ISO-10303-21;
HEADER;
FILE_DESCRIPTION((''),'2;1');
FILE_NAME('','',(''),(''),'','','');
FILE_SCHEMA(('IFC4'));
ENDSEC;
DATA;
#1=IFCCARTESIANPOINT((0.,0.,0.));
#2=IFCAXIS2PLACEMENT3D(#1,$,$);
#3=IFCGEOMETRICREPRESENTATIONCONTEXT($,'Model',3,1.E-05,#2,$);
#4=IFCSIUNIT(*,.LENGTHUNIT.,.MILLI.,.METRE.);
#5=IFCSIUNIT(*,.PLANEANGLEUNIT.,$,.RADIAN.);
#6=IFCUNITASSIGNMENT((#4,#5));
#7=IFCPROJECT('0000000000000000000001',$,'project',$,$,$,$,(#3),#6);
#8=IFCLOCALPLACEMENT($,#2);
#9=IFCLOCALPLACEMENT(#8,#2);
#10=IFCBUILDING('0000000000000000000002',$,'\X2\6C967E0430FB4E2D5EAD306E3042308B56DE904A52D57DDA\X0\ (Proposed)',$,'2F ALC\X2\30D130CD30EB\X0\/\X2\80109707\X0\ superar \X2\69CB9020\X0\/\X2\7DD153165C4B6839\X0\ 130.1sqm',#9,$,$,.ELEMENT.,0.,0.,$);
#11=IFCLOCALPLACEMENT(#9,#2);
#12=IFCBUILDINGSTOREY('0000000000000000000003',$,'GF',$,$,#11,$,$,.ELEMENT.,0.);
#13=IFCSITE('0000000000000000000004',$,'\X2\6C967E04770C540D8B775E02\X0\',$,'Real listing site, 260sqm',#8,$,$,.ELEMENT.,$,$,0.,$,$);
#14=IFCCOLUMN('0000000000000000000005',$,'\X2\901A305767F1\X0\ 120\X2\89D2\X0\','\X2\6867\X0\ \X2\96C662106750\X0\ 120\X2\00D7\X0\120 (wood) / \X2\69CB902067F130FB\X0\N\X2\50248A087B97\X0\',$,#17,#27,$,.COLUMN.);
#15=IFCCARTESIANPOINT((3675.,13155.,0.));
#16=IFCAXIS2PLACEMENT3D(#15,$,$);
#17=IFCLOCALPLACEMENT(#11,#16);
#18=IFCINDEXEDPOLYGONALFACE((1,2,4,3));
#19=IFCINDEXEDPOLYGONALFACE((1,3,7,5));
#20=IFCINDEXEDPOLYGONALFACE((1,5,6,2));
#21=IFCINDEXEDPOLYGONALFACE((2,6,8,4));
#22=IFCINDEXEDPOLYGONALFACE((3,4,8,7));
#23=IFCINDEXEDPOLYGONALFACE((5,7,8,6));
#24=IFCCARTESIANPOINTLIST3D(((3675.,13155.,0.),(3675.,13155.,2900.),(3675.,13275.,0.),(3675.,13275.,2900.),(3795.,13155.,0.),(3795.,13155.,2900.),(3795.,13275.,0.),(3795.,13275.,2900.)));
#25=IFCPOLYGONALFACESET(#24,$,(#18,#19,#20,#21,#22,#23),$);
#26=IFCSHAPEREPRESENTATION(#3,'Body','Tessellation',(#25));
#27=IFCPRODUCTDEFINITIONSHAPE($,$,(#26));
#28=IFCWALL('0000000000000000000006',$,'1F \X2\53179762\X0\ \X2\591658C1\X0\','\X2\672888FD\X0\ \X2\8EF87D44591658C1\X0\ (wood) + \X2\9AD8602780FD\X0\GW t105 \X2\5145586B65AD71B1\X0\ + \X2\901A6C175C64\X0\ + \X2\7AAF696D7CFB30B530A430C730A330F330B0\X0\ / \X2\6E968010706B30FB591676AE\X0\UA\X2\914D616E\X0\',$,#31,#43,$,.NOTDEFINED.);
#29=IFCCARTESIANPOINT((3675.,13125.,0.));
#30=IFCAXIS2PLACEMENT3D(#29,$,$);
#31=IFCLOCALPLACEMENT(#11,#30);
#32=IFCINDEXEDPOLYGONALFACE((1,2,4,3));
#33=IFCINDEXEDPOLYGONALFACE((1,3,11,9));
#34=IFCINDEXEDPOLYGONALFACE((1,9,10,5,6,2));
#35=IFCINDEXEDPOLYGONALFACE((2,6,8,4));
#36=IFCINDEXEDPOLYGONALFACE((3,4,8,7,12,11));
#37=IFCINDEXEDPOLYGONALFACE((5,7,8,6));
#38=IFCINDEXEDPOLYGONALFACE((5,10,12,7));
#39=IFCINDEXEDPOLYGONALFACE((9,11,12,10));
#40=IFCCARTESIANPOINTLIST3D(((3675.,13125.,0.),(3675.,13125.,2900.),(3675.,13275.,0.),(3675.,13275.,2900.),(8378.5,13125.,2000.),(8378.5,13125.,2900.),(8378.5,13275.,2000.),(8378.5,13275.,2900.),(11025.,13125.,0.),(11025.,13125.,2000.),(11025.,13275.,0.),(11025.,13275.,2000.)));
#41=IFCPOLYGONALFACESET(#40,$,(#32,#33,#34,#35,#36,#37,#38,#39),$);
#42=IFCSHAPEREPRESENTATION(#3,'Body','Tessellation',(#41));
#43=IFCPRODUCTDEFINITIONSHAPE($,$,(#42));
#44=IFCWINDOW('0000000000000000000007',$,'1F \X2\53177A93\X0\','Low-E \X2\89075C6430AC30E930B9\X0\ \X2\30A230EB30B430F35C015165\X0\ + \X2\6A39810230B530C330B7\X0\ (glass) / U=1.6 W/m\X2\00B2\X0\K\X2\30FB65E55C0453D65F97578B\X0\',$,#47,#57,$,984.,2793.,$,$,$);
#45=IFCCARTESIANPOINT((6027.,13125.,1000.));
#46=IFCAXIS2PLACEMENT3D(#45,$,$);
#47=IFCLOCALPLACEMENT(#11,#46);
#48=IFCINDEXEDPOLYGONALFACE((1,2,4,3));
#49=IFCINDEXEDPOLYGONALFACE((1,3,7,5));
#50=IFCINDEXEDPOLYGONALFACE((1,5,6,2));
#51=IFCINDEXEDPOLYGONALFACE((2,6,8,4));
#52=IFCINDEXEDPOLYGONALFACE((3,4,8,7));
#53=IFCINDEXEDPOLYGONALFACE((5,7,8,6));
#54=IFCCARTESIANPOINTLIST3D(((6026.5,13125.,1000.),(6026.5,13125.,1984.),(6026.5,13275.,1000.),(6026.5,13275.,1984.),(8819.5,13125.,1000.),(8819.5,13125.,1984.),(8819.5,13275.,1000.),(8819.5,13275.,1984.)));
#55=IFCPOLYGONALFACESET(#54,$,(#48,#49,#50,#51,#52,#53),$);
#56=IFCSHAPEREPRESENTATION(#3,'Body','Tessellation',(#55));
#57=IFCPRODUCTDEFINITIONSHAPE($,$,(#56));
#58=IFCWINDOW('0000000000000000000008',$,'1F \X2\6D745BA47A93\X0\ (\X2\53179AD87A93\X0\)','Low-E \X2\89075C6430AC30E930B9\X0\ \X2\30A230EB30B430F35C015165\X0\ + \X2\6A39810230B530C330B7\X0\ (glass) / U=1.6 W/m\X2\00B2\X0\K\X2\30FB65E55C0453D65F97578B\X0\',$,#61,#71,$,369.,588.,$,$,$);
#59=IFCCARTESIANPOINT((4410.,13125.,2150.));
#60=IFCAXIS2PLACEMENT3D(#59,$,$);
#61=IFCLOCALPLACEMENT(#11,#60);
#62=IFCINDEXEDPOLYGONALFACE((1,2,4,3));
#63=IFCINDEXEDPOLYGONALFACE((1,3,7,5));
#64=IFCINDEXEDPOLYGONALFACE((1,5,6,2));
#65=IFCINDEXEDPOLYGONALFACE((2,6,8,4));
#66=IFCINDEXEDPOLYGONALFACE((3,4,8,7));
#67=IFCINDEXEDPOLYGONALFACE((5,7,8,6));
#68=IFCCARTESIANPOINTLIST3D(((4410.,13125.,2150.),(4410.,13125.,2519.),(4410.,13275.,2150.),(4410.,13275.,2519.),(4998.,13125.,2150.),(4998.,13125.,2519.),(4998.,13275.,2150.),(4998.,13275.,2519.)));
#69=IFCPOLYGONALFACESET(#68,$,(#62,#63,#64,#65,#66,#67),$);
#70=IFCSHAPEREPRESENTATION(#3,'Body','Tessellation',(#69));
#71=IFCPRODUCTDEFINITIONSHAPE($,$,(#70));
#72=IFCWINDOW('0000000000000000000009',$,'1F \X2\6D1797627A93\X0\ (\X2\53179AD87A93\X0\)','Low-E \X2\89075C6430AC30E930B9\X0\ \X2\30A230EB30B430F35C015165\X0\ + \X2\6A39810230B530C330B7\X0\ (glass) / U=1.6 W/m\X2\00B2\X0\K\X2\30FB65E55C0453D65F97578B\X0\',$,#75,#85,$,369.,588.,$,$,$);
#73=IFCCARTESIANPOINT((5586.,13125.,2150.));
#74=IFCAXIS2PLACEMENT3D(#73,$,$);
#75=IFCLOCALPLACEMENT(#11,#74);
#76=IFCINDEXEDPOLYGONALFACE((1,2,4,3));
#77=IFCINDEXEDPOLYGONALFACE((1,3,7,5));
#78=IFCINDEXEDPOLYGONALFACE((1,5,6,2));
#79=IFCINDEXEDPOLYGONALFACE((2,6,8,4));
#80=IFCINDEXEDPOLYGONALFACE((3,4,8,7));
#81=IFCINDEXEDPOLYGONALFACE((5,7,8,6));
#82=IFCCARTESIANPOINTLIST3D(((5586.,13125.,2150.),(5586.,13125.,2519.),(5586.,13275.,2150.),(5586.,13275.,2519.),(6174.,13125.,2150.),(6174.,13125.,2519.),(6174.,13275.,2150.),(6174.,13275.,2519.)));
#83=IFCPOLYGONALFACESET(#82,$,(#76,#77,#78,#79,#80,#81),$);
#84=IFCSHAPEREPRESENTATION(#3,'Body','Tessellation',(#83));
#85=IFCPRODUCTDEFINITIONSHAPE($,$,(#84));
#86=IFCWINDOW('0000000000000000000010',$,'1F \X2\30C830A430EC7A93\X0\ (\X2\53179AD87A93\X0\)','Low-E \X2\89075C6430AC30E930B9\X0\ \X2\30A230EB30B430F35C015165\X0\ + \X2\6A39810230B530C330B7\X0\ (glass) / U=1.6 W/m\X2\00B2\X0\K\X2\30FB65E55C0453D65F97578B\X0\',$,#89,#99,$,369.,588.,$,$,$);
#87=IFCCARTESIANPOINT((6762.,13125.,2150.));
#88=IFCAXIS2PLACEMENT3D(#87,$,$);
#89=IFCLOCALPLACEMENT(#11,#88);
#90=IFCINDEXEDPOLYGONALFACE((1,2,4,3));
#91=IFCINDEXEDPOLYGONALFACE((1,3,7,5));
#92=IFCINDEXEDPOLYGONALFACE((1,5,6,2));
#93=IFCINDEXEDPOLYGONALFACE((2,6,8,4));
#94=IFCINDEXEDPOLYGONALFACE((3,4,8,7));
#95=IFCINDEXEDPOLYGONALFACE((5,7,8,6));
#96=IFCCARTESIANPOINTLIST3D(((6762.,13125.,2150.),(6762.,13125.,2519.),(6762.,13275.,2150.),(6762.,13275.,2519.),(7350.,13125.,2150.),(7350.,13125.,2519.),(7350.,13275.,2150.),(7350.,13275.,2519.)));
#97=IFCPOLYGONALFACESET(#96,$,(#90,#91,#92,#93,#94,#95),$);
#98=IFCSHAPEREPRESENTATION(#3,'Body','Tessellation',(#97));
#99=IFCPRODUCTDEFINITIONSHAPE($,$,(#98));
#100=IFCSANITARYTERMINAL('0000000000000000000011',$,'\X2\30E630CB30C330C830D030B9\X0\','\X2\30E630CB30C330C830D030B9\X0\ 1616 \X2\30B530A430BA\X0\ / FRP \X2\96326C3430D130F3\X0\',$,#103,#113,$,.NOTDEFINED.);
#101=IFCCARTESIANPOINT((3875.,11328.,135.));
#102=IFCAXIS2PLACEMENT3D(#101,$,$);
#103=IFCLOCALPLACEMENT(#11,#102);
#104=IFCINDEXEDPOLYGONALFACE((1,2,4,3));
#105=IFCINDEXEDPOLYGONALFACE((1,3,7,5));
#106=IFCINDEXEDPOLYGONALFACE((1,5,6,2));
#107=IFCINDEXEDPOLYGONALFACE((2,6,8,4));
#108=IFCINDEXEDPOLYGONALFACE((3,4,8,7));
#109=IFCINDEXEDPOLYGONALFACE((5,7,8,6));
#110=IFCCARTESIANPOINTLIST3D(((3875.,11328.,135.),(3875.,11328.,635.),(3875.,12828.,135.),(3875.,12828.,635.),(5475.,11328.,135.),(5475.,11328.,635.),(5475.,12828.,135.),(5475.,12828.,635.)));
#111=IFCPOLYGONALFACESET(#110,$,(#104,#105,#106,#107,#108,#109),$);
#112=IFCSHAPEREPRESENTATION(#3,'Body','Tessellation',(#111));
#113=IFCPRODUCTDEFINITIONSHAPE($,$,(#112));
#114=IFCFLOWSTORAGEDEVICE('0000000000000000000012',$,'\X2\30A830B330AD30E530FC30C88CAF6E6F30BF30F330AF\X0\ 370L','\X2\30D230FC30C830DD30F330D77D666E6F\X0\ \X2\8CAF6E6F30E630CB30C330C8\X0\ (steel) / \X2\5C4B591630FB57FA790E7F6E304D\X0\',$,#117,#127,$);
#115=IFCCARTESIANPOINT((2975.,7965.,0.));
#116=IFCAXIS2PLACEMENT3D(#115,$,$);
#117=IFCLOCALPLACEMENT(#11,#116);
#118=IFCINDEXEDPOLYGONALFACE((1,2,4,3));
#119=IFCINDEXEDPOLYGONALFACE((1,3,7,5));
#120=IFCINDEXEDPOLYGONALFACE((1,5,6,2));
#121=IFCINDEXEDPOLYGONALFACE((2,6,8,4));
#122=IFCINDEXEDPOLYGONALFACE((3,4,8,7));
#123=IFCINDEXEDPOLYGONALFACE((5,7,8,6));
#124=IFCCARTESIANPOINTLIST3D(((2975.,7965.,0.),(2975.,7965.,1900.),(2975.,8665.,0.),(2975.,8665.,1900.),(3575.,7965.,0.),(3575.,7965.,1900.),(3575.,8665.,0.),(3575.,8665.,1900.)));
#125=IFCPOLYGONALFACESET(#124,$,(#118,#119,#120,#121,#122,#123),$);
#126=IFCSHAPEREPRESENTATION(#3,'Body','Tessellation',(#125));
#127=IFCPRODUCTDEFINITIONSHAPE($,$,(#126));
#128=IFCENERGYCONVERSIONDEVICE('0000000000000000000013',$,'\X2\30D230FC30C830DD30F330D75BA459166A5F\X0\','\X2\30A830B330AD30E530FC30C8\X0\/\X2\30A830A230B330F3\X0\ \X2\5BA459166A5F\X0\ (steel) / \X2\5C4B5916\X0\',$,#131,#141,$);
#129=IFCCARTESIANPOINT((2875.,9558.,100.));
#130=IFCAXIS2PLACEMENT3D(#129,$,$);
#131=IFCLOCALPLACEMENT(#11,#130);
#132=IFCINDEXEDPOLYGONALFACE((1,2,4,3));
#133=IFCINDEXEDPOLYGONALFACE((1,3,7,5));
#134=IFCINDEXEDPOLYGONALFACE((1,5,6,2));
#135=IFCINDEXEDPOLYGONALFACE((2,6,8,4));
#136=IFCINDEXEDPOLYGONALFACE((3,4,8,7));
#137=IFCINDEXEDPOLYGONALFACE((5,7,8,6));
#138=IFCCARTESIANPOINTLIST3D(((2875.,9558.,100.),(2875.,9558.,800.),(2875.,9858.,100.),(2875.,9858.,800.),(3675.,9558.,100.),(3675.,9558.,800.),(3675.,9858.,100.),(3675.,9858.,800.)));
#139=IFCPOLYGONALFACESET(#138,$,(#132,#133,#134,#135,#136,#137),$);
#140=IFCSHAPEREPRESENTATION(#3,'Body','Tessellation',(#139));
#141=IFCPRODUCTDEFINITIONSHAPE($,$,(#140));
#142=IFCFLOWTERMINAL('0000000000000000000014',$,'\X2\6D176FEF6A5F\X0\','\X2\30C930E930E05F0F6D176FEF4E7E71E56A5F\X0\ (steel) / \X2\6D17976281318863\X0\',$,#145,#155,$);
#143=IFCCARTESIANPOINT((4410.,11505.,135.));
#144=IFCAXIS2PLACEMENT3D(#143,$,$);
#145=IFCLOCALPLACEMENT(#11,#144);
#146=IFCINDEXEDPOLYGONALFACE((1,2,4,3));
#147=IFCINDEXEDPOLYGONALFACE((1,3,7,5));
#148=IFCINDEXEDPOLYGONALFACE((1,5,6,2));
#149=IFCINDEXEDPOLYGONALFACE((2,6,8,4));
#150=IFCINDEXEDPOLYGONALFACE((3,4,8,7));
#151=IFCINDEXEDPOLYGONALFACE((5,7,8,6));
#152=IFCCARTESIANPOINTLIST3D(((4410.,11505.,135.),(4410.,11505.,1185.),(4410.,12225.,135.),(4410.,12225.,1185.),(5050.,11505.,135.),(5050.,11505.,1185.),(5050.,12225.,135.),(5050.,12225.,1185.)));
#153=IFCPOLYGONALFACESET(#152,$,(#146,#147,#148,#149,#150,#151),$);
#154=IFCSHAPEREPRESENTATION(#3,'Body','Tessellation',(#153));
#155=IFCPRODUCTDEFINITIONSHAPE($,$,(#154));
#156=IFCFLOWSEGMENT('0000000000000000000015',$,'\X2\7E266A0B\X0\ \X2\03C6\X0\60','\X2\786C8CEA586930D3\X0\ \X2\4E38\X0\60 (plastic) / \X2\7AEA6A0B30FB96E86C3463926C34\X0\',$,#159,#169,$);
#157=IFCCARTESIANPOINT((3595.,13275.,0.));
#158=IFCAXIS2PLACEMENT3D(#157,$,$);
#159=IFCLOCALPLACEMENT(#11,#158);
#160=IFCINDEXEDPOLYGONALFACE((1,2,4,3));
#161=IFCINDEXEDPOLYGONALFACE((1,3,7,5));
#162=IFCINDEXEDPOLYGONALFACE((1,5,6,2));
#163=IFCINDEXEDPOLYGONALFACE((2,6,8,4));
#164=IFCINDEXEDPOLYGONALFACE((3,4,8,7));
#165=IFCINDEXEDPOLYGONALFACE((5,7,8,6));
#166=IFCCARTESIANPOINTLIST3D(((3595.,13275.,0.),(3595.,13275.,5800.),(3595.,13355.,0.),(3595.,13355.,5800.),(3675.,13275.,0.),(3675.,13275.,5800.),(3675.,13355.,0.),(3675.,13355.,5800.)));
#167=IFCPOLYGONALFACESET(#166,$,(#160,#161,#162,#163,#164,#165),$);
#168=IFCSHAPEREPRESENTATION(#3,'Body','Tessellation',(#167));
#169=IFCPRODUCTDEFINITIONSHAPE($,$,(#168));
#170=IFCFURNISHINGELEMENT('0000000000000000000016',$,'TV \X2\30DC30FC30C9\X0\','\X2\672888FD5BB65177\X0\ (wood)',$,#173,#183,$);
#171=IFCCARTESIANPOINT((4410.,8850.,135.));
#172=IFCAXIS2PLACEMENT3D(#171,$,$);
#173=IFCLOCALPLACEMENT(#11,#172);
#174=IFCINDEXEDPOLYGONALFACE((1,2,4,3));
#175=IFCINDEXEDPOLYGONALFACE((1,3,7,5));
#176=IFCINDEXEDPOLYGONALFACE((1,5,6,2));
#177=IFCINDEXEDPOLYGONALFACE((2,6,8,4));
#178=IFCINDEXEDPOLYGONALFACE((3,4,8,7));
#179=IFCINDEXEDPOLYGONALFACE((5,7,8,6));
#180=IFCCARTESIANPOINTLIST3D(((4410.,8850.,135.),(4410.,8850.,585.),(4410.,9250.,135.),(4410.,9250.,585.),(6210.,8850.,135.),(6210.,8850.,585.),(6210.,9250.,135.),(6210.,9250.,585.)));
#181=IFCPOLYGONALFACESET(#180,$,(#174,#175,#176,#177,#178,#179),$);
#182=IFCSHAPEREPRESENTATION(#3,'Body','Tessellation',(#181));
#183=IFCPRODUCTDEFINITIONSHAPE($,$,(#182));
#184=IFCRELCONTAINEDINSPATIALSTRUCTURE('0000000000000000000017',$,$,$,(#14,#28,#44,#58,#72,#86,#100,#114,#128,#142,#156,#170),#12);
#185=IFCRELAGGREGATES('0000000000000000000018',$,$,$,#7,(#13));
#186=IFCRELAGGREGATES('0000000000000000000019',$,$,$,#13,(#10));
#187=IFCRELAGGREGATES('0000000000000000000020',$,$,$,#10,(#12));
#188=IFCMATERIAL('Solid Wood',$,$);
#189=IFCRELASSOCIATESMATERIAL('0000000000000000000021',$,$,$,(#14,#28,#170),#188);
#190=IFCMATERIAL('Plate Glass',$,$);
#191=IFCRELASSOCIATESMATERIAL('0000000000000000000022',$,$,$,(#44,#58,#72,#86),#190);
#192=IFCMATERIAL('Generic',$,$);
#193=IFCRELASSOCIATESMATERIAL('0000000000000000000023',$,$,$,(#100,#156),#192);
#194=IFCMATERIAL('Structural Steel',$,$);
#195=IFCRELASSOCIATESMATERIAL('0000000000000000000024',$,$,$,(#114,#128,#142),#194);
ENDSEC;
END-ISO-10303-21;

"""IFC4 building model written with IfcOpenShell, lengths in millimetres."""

from ifc_helpers import new_model, si_unit, frame, frame_2d, origin, place, context, project, spatial, rectangle, extrude, material, element, fill, save


model = new_model("IFC4")

# Units and contexts
model_context = context("Model", 3, precision=1e-05, world=origin())
ifc_project = project(units=[si_unit("LENGTHUNIT", "METRE", prefix="MILLI"), si_unit("PLANEANGLEUNIT", "RADIAN")], contexts=[model_context])

# Site, building, storey
site_placement = place(None, origin())
site = spatial("IfcSite", under=ifc_project, at=site_placement, Name="沖縄県名護市", ObjectType="Real listing site, 260sqm", CompositionType="ELEMENT", RefElevation=0.0)
building_placement = place(site_placement, origin())
building = spatial("IfcBuilding", under=site, at=building_placement, Name="沖縄・中庭のある回遊動線 (Proposed)", ObjectType="2F ALCパネル/耐震 superar 構造/緑化屋根 130.1sqm", CompositionType="ELEMENT", ElevationOfRefHeight=0.0, ElevationOfTerrain=0.0)
storey_placement = place(building_placement, origin())
storey = spatial("IfcBuildingStorey", under=building, at=storey_placement, Name="GF", CompositionType="ELEMENT", Elevation=0.0)

# Column
ifc_material_1 = material(Name="Solid Wood")
column_1_placement = place(storey_placement, frame((3675.0, 13155.0, 0.0)))
element("IfcColumn", 1, at=column_1_placement, inside=storey, material=ifc_material_1, Name="通し柱 120角", Description="桧 集成材 120×120 (wood) / 構造柱・N値計算", PredefinedType="COLUMN", context=model_context, shape_type="SweptSolid", body=[
    extrude(rectangle(XDim=120.0, YDim=120.0, at=frame_2d((60.0, 60.0))), frame((3675.0, 13155.0, 0.0)), (0.0, 0.0, 1.0), 2900.0),
])

# Wall, openings, windows
wall_1_placement = place(storey_placement, frame((3675.0, 13125.0, 0.0)))
wall_1 = element("IfcWall", 2, at=wall_1_placement, inside=storey, material=ifc_material_1, Name="1F 北面 外壁", Description="木製 軸組外壁 (wood) + 高性能GW t105 充填断熱 + 通気層 + 窯業系サイディング / 準耐火・外皮UA配慮", PredefinedType="NOTDEFINED", context=model_context, shape_type="SweptSolid", body=[
    extrude(rectangle(XDim=7350.0, YDim=150.0, at=frame_2d((3675.0, 75.0))), frame((3675.0, 13125.0, 0.0)), (0.0, 0.0, 1.0), 2900.0),
])
opening_1_placement = place(storey_placement, frame((6027.0, 13125.0, 1000.0)))
opening_1 = element("IfcOpeningElement", 3, at=opening_1_placement, cuts=wall_1, PredefinedType="NOTDEFINED", context=model_context, shape_type="SweptSolid", body=[
    extrude(rectangle(XDim=2793.0, YDim=150.0, at=frame_2d((1396.0, 75.0))), frame((6027.0, 13125.0, 1000.0)), (0.0, 0.0, 1.0), 984.0),
])
opening_2_placement = place(storey_placement, frame((4410.0, 13125.0, 2150.0)))
opening_2 = element("IfcOpeningElement", 4, at=opening_2_placement, cuts=wall_1, PredefinedType="NOTDEFINED", context=model_context, shape_type="SweptSolid", body=[
    extrude(rectangle(XDim=588.0, YDim=150.0, at=frame_2d((294.0, 75.0))), frame((4410.0, 13125.0, 2150.0)), (0.0, 0.0, 1.0), 369.0),
])
opening_3_placement = place(storey_placement, frame((5586.0, 13125.0, 2150.0)))
opening_3 = element("IfcOpeningElement", 5, at=opening_3_placement, cuts=wall_1, PredefinedType="NOTDEFINED", context=model_context, shape_type="SweptSolid", body=[
    extrude(rectangle(XDim=588.0, YDim=150.0, at=frame_2d((294.0, 75.0))), frame((5586.0, 13125.0, 2150.0)), (0.0, 0.0, 1.0), 369.0),
])
opening_4_placement = place(storey_placement, frame((6762.0, 13125.0, 2150.0)))
opening_4 = element("IfcOpeningElement", 6, at=opening_4_placement, cuts=wall_1, PredefinedType="NOTDEFINED", context=model_context, shape_type="SweptSolid", body=[
    extrude(rectangle(XDim=588.0, YDim=150.0, at=frame_2d((294.0, 75.0))), frame((6762.0, 13125.0, 2150.0)), (0.0, 0.0, 1.0), 369.0),
])
ifc_material_2 = material(Name="Plate Glass")
window_1_placement = place(storey_placement, frame((6027.0, 13125.0, 1000.0)))
window_1 = element("IfcWindow", 7, at=window_1_placement, inside=storey, material=ifc_material_2, Name="1F 北窓", Description="Low-E 複層ガラス アルゴン封入 + 樹脂サッシ (glass) / U=1.6 W/m²K・日射取得型", OverallHeight=984.0, OverallWidth=2793.0, context=model_context, shape_type="SweptSolid", body=[
    extrude(rectangle(XDim=2793.0, YDim=150.0, at=frame_2d((1396.0, 75.0))), frame((6027.0, 13125.0, 1000.0)), (0.0, 0.0, 1.0), 984.0),
])
fill(opening_1, window_1)
window_2_placement = place(storey_placement, frame((4410.0, 13125.0, 2150.0)))
window_2 = element("IfcWindow", 8, at=window_2_placement, inside=storey, material=ifc_material_2, Name="1F 浴室窓 (北高窓)", Description="Low-E 複層ガラス アルゴン封入 + 樹脂サッシ (glass) / U=1.6 W/m²K・日射取得型", OverallHeight=369.0, OverallWidth=588.0, context=model_context, shape_type="SweptSolid", body=[
    extrude(rectangle(XDim=588.0, YDim=150.0, at=frame_2d((294.0, 75.0))), frame((4410.0, 13125.0, 2150.0)), (0.0, 0.0, 1.0), 369.0),
])
fill(opening_2, window_2)
window_3_placement = place(storey_placement, frame((5586.0, 13125.0, 2150.0)))
window_3 = element("IfcWindow", 9, at=window_3_placement, inside=storey, material=ifc_material_2, Name="1F 洗面窓 (北高窓)", Description="Low-E 複層ガラス アルゴン封入 + 樹脂サッシ (glass) / U=1.6 W/m²K・日射取得型", OverallHeight=369.0, OverallWidth=588.0, context=model_context, shape_type="SweptSolid", body=[
    extrude(rectangle(XDim=588.0, YDim=150.0, at=frame_2d((294.0, 75.0))), frame((5586.0, 13125.0, 2150.0)), (0.0, 0.0, 1.0), 369.0),
])
fill(opening_3, window_3)
window_4_placement = place(storey_placement, frame((6762.0, 13125.0, 2150.0)))
window_4 = element("IfcWindow", 10, at=window_4_placement, inside=storey, material=ifc_material_2, Name="1F トイレ窓 (北高窓)", Description="Low-E 複層ガラス アルゴン封入 + 樹脂サッシ (glass) / U=1.6 W/m²K・日射取得型", OverallHeight=369.0, OverallWidth=588.0, context=model_context, shape_type="SweptSolid", body=[
    extrude(rectangle(XDim=588.0, YDim=150.0, at=frame_2d((294.0, 75.0))), frame((6762.0, 13125.0, 2150.0)), (0.0, 0.0, 1.0), 369.0),
])
fill(opening_4, window_4)

# Sanitary terminal
ifc_material_3 = material(Name="Generic")
sanitary_terminal_placement = place(storey_placement, frame((3875.0, 11328.0, 135.0)))
element("IfcSanitaryTerminal", 11, at=sanitary_terminal_placement, inside=storey, material=ifc_material_3, Name="ユニットバス", Description="ユニットバス 1616 サイズ / FRP 防水パン", PredefinedType="NOTDEFINED", context=model_context, shape_type="SweptSolid", body=[
    extrude(rectangle(XDim=1600.0, YDim=1500.0, at=frame_2d((800.0, 750.0))), frame((3875.0, 11328.0, 135.0)), (0.0, 0.0, 1.0), 500.0),
])

# Flow storage device
ifc_material_4 = material(Name="Structural Steel")
flow_storage_device_placement = place(storey_placement, frame((2975.0, 7965.0, 0.0)))
element("IfcFlowStorageDevice", 12, at=flow_storage_device_placement, inside=storey, material=ifc_material_4, Name="エコキュート貯湯タンク 370L", Description="ヒートポンプ給湯 貯湯ユニット (steel) / 屋外・基礎置き", context=model_context, shape_type="SweptSolid", body=[
    extrude(rectangle(XDim=600.0, YDim=700.0, at=frame_2d((300.0, 350.0))), frame((2975.0, 7965.0, 0.0)), (0.0, 0.0, 1.0), 1900.0),
])

# Energy conversion device
energy_conversion_device_placement = place(storey_placement, frame((2875.0, 9558.0, 100.0)))
element("IfcEnergyConversionDevice", 13, at=energy_conversion_device_placement, inside=storey, material=ifc_material_4, Name="ヒートポンプ室外機", Description="エコキュート/エアコン 室外機 (steel) / 屋外", context=model_context, shape_type="SweptSolid", body=[
    extrude(rectangle(XDim=800.0, YDim=300.0, at=frame_2d((400.0, 150.0))), frame((2875.0, 9558.0, 100.0)), (0.0, 0.0, 1.0), 700.0),
])

# Flow terminal
flow_terminal_placement = place(storey_placement, frame((4410.0, 11505.0, 135.0)))
element("IfcFlowTerminal", 14, at=flow_terminal_placement, inside=storey, material=ifc_material_4, Name="洗濯機", Description="ドラム式洗濯乾燥機 (steel) / 洗面脱衣", context=model_context, shape_type="SweptSolid", body=[
    extrude(rectangle(XDim=640.0, YDim=720.0, at=frame_2d((320.0, 360.0))), frame((4410.0, 11505.0, 135.0)), (0.0, 0.0, 1.0), 1050.0),
])

# Flow segment
flow_segment_placement = place(storey_placement, frame((3595.0, 13275.0, 0.0)))
element("IfcFlowSegment", 15, at=flow_segment_placement, inside=storey, material=ifc_material_3, Name="縦樋 φ60", Description="硬質塩ビ 丸60 (plastic) / 竪樋・雨水排水", context=model_context, shape_type="SweptSolid", body=[
    extrude(rectangle(XDim=80.0, YDim=80.0, at=frame_2d((40.0, 40.0))), frame((3595.0, 13275.0, 0.0)), (0.0, 0.0, 1.0), 5800.0),
])

# Furnishing element
furnishing_placement = place(storey_placement, frame((4410.0, 8850.0, 135.0)))
element("IfcFurnishingElement", 16, at=furnishing_placement, inside=storey, material=ifc_material_1, Name="TV ボード", Description="木製家具 (wood)", context=model_context, shape_type="SweptSolid", body=[
    extrude(rectangle(XDim=1800.0, YDim=400.0, at=frame_2d((900.0, 200.0))), frame((4410.0, 8850.0, 135.0)), (0.0, 0.0, 1.0), 450.0),
])

save(model, "model.ifc")
